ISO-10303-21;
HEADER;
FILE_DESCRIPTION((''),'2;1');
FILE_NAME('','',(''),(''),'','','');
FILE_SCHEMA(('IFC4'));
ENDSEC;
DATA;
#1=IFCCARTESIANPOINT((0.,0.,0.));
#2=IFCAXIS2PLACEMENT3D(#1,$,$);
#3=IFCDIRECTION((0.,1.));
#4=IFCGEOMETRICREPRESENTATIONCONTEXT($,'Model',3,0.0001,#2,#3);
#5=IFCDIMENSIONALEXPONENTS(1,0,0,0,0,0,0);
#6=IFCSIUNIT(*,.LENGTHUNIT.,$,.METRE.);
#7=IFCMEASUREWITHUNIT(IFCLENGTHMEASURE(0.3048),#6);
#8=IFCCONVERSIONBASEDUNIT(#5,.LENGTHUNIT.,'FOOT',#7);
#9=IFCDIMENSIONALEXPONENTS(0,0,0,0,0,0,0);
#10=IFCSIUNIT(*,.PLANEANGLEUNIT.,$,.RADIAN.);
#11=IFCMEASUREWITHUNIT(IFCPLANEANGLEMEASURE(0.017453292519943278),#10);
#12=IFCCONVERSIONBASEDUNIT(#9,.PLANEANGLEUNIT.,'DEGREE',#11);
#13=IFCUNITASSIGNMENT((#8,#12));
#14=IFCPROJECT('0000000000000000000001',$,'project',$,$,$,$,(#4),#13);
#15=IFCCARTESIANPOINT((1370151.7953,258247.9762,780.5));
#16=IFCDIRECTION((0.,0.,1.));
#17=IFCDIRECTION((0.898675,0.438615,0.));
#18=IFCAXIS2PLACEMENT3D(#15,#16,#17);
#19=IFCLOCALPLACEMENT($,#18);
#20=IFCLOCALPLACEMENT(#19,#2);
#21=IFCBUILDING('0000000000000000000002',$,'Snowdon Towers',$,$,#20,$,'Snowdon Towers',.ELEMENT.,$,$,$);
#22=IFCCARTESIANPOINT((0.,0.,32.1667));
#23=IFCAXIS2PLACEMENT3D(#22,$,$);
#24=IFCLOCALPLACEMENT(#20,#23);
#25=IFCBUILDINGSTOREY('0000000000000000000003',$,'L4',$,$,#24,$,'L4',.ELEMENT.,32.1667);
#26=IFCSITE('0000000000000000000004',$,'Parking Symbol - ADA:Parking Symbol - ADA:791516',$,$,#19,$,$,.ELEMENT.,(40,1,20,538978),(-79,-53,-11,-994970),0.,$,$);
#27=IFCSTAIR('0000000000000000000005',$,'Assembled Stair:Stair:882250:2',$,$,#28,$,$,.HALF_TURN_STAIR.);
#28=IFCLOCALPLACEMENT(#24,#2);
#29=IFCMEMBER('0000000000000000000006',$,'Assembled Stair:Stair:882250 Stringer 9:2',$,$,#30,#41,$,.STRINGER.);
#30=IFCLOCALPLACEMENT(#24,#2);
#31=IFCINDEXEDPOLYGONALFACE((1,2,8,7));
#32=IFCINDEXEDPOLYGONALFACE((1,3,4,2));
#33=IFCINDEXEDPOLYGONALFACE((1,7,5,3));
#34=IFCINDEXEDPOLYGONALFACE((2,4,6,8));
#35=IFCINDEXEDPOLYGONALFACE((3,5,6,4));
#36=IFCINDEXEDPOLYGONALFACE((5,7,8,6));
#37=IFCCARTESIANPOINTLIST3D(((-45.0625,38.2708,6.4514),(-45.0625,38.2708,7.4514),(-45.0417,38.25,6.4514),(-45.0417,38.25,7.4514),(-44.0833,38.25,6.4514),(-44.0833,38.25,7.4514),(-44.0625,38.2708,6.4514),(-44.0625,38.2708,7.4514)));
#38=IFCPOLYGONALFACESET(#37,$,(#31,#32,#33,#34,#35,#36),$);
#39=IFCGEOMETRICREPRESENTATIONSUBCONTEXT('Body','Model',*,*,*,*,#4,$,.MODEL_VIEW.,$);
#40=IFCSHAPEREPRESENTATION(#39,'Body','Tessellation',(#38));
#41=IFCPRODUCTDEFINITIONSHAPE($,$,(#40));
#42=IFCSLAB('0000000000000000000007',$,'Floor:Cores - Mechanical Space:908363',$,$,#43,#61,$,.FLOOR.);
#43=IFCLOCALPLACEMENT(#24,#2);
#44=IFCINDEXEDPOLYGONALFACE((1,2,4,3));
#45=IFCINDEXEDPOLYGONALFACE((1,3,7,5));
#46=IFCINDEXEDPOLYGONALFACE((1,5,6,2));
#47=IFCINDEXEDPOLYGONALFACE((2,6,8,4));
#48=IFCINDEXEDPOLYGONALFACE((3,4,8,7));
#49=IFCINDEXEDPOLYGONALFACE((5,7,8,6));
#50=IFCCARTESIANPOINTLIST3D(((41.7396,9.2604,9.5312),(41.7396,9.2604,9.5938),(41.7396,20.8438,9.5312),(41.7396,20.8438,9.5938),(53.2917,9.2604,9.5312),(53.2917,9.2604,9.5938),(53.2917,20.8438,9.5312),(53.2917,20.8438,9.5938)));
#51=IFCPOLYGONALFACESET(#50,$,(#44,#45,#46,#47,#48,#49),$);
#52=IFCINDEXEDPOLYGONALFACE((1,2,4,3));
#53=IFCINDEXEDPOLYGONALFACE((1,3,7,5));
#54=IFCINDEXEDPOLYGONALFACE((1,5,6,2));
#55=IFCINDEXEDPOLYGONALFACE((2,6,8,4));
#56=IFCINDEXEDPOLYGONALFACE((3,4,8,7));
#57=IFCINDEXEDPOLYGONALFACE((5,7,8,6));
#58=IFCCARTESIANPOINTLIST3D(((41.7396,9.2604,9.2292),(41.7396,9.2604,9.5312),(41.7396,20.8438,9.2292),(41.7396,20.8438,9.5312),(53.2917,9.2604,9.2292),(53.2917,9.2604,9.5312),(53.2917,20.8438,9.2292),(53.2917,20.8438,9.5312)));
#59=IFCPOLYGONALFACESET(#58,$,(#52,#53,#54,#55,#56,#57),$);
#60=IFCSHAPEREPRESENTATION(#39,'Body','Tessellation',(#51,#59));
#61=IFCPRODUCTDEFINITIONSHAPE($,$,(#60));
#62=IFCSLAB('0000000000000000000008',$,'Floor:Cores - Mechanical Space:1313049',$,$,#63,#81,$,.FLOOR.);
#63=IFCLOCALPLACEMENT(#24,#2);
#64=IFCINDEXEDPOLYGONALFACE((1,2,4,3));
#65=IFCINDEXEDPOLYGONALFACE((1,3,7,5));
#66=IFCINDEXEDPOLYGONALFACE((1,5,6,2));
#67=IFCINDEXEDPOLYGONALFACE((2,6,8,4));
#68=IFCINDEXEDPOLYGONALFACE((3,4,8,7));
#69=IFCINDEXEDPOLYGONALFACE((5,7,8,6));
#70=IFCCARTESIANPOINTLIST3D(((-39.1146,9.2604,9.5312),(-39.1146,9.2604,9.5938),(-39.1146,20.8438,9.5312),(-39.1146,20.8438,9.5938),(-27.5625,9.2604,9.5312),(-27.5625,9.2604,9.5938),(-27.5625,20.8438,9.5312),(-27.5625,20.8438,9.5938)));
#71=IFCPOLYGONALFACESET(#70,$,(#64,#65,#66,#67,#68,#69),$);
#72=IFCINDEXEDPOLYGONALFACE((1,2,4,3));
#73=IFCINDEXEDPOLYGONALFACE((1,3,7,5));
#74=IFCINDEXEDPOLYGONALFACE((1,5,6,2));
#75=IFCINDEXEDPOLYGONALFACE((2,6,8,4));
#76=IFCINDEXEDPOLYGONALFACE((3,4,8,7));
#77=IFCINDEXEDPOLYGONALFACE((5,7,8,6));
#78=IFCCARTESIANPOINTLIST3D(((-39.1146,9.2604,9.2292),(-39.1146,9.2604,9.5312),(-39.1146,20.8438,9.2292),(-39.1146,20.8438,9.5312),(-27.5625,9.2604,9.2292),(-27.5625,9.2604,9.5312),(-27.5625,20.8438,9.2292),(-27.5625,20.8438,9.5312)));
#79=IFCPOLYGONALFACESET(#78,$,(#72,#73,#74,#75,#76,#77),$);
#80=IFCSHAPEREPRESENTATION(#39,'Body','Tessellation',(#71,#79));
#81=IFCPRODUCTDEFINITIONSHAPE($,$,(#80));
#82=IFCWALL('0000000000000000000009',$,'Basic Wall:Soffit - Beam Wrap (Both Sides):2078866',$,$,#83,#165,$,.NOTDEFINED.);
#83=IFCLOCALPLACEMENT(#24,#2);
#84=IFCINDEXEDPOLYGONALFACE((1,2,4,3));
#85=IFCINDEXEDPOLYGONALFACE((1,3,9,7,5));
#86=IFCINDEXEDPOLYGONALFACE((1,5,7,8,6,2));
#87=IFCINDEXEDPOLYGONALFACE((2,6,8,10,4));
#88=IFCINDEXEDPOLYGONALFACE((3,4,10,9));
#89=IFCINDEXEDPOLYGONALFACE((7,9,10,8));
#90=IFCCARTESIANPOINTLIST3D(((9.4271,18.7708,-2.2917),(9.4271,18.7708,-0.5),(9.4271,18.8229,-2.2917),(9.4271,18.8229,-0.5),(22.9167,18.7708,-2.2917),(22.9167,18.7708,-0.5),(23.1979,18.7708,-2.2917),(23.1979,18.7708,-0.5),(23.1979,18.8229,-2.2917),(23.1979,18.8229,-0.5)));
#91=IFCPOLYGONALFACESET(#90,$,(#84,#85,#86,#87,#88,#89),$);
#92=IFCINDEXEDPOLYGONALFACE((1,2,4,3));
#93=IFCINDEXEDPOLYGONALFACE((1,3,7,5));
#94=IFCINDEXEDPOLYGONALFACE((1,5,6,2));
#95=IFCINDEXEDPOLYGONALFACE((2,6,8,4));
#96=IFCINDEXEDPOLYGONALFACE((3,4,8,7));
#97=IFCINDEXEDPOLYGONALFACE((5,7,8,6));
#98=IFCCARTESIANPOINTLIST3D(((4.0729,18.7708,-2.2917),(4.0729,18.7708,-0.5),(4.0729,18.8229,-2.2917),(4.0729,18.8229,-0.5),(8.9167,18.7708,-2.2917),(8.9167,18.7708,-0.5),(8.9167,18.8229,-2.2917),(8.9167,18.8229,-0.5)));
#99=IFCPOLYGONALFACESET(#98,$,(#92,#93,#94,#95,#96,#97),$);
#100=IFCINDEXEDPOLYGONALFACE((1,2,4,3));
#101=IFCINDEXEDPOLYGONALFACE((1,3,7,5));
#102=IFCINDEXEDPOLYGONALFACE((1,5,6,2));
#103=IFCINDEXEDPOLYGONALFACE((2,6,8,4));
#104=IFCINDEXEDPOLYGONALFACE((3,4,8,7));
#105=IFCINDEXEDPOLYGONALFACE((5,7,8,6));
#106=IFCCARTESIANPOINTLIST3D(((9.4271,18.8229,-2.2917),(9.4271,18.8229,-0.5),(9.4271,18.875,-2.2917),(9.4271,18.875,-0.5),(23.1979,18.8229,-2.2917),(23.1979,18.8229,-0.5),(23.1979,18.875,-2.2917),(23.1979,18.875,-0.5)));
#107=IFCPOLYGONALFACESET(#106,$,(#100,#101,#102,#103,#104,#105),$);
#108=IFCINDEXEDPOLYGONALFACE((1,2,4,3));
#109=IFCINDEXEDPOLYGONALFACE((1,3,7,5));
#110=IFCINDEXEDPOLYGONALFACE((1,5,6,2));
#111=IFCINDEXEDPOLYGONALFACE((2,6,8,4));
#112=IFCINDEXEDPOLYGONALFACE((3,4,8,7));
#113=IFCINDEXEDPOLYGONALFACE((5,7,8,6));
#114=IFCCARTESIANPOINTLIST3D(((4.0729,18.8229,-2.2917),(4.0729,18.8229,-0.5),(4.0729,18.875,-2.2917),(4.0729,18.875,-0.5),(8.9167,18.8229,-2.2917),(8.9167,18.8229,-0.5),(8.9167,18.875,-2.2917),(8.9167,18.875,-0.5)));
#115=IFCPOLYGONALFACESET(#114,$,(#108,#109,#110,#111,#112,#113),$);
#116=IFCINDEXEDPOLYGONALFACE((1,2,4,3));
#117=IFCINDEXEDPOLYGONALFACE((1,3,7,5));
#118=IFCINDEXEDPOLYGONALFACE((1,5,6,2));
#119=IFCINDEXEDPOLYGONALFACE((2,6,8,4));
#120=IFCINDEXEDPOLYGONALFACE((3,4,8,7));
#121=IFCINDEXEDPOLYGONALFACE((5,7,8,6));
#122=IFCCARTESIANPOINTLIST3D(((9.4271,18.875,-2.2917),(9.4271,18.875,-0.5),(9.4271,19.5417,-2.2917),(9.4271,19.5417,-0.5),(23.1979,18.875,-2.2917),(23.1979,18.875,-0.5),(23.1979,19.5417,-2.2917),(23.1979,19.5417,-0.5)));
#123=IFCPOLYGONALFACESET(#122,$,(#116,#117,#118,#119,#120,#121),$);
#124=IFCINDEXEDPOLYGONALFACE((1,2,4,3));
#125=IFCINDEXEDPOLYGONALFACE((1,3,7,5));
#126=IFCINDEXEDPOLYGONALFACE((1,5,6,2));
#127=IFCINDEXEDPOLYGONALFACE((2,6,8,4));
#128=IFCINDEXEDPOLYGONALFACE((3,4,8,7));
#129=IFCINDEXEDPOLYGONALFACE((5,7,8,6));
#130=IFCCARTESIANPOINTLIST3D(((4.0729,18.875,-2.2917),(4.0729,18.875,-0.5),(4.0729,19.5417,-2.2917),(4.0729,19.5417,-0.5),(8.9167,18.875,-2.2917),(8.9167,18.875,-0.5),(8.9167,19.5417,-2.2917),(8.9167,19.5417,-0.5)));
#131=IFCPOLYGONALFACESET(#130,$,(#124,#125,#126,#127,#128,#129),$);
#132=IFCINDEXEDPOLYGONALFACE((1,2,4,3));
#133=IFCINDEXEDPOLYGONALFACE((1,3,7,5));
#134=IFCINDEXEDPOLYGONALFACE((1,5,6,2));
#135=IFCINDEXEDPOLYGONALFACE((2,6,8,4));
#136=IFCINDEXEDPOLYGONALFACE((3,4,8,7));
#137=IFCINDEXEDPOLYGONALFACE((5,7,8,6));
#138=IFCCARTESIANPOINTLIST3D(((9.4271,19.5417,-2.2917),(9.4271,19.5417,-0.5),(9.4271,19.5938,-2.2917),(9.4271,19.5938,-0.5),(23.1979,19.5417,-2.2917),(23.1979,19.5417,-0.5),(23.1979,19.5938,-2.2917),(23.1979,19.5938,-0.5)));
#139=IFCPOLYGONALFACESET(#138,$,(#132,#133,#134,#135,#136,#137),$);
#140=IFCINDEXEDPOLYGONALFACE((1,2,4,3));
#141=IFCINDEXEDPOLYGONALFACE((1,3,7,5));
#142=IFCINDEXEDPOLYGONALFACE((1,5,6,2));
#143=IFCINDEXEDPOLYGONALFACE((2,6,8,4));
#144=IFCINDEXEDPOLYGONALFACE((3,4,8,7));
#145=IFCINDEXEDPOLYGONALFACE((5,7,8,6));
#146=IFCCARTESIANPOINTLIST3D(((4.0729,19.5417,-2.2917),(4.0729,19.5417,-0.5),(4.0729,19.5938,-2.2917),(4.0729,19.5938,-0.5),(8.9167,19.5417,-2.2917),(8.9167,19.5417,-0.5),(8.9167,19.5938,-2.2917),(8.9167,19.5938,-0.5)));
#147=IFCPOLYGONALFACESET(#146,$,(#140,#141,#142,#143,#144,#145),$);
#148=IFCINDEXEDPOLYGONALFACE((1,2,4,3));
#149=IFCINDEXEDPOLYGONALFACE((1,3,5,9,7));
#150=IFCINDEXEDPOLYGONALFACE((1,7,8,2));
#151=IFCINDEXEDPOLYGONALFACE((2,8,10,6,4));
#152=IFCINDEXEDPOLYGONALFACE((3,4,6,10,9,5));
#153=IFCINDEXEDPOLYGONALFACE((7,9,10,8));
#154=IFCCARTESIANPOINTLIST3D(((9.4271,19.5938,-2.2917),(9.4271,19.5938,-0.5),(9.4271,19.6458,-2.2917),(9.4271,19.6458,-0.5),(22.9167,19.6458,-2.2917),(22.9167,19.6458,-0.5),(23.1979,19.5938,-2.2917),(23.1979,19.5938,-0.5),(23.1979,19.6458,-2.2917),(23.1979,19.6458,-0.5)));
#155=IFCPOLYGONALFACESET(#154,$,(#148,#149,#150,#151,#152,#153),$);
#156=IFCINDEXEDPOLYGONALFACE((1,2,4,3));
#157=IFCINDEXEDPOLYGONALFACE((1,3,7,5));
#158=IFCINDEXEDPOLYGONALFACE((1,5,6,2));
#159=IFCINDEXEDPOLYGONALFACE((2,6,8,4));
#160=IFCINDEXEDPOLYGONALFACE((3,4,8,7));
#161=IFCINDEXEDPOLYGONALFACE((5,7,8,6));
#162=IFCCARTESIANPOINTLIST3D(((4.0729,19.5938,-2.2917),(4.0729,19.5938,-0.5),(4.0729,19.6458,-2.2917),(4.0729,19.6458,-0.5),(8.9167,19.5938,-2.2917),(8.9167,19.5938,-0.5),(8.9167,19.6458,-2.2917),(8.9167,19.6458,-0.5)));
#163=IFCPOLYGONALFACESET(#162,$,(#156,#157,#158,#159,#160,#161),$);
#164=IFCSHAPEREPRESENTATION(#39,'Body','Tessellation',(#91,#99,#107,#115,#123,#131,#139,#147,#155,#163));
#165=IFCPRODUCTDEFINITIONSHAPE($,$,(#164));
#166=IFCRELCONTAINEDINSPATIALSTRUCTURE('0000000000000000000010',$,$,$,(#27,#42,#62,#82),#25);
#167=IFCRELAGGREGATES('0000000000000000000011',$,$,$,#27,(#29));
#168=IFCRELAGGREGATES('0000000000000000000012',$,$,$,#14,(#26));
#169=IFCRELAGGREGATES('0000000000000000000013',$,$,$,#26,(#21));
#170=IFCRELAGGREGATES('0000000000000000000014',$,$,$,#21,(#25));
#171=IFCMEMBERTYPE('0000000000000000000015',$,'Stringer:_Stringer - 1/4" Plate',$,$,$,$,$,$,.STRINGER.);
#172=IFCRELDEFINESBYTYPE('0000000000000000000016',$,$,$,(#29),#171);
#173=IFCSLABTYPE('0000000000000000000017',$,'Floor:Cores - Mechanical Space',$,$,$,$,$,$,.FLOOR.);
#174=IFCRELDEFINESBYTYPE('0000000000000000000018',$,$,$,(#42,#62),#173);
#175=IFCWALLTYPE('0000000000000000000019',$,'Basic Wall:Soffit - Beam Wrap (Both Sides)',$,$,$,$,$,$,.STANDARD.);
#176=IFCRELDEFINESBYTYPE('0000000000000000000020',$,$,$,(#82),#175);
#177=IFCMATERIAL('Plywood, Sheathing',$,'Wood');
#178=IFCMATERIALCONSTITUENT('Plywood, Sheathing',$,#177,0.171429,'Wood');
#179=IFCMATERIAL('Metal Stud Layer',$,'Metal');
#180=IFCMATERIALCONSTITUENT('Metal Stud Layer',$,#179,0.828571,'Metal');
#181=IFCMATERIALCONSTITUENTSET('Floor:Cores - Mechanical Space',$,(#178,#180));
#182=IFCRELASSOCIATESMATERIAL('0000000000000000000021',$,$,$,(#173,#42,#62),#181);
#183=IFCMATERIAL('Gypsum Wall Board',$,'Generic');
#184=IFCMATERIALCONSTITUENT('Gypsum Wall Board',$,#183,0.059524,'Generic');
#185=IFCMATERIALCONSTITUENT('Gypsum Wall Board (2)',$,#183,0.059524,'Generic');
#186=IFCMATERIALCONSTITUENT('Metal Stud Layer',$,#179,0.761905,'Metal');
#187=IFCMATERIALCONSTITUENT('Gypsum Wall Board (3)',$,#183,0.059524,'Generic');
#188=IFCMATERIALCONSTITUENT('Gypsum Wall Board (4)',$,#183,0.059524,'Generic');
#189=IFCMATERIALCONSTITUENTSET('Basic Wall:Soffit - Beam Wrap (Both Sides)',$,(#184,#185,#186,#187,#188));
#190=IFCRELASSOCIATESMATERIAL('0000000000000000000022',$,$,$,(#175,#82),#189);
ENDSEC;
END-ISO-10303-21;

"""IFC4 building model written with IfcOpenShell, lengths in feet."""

from ifc_helpers import new_model, entity, si_unit, converted_unit, direction, frame, origin, place, context, subcontext, project, spatial, indexed_curve, outline, extrude, material, constituent, constituent_set, type_object, element, aggregate, save


model = new_model("IFC4")

# Units and contexts
model_context = context("Model", 3, precision=0.0001, world=origin(), true_north=direction((0.0, 1.0)))
body_context = subcontext(model_context, "Body", "Model", "MODEL_VIEW")
ifc_project = project(units=[converted_unit("LENGTHUNIT", "FOOT", entity("IfcLengthMeasure", 0.3048), si_unit("LENGTHUNIT", "METRE"), dimensions=[1, 0, 0, 0, 0, 0, 0]), converted_unit("PLANEANGLEUNIT", "DEGREE", entity("IfcPlaneAngleMeasure", 0.017453292519943278), si_unit("PLANEANGLEUNIT", "RADIAN"), dimensions=[0, 0, 0, 0, 0, 0, 0])], contexts=[model_context])

# Site, building, storey
site_placement = place(None, frame((1370151.7953, 258247.9762, 780.5), z_axis=(0.0, 0.0, 1.0), x_axis=(0.898675, 0.438615, 0.0)))
site = spatial("IfcSite", under=ifc_project, at=site_placement, Name="Parking Symbol - ADA:Parking Symbol - ADA:791516", CompositionType="ELEMENT", RefLatitude=(40, 1, 20, 538978), RefLongitude=(-79, -53, -11, -994970), RefElevation=0.0)
building_placement = place(site_placement, origin())
building = spatial("IfcBuilding", under=site, at=building_placement, Name="Snowdon Towers", LongName="Snowdon Towers", CompositionType="ELEMENT")
storey_placement = place(building_placement, frame((0.0, 0.0, 32.1667)))
storey = spatial("IfcBuildingStorey", under=building, at=storey_placement, Name="L4", LongName="L4", CompositionType="ELEMENT", Elevation=32.1667)

# Shared definitions
ifc_material_1 = material(Name="Gypsum Wall Board", Category="Generic")

# Stair, member
stair_placement = place(storey_placement, origin())
stair = element("IfcStair", 1, at=stair_placement, inside=storey, Name="Assembled Stair:Stair:882250:2", PredefinedType="HALF_TURN_STAIR")
member_type = type_object("IfcMemberType", Name="Stringer:_Stringer - 1/4\" Plate", PredefinedType="STRINGER")
member_1_placement = place(stair_placement, origin())
member_1 = element("IfcMember", 2, at=member_1_placement, type_object=member_type, Name="Assembled Stair:Stair:882250 Stringer 9:2", PredefinedType="STRINGER", context=body_context, shape_type="SweptSolid", body=[
    extrude(outline(indexed_curve([(-0.4792, -0.0104), (0.4792, -0.0104), (0.5, 0.0104), (-0.5, 0.0104), (-0.4792, -0.0104)], self_intersect=False)), frame((-44.5625, 38.2604, 6.4514)), (0.0, 0.0, 1.0), 1.0),
])
aggregate(stair, [member_1])

# Slabs
ifc_material_2 = material(Name="Plywood, Sheathing", Category="Wood")
ifc_constituent_1 = constituent(ifc_material_2, Name="Plywood, Sheathing", Category="Wood", fraction=0.171429)
ifc_material_3 = material(Name="Metal Stud Layer", Category="Metal")
ifc_constituent_2 = constituent(ifc_material_3, Name="Metal Stud Layer", Category="Metal", fraction=0.828571)
ifc_constituent_set_1 = constituent_set(constituents=[ifc_constituent_1, ifc_constituent_2], Name="Floor:Cores - Mechanical Space")
slab_type_1 = type_object("IfcSlabType", Name="Floor:Cores - Mechanical Space", PredefinedType="FLOOR", material=ifc_constituent_set_1)
slab_1_placement = place(storey_placement, origin())
element("IfcSlab", 3, at=slab_1_placement, inside=storey, type_object=slab_type_1, material=ifc_constituent_set_1, Name="Floor:Cores - Mechanical Space:908363", PredefinedType="FLOOR", context=body_context, shape_type="SweptSolid", body=[
    extrude(outline(indexed_curve([(-5.7917, -5.776), (5.7917, -5.776), (5.7917, 5.776), (-5.7917, 5.776), (-5.7917, -5.776)], self_intersect=False)), frame((47.5156, 15.0521, 9.5312), z_axis=(0.0, 0.0, 1.0), x_axis=(0.0, 1.0, 0.0)), (0.0, 0.0, 1.0), 0.0625),
    extrude(outline(indexed_curve([(-5.7917, -5.776), (5.7917, -5.776), (5.7917, 5.776), (-5.7917, 5.776), (-5.7917, -5.776)], self_intersect=False)), frame((47.5156, 15.0521, 9.2292), z_axis=(0.0, 0.0, 1.0), x_axis=(0.0, 1.0, 0.0)), (0.0, 0.0, 1.0), 0.3021),
])
slab_2_placement = place(storey_placement, origin())
element("IfcSlab", 4, at=slab_2_placement, inside=storey, type_object=slab_type_1, material=ifc_constituent_set_1, Name="Floor:Cores - Mechanical Space:1313049", PredefinedType="FLOOR", context=body_context, shape_type="SweptSolid", body=[
    extrude(outline(indexed_curve([(-5.7917, -5.776), (5.7917, -5.776), (5.7917, 5.776), (-5.7917, 5.776), (-5.7917, -5.776)], self_intersect=False)), frame((-33.3385, 15.0521, 9.5312), z_axis=(0.0, 0.0, 1.0), x_axis=(0.0, 1.0, 0.0)), (0.0, 0.0, 1.0), 0.0625),
    extrude(outline(indexed_curve([(-5.7917, -5.776), (5.7917, -5.776), (5.7917, 5.776), (-5.7917, 5.776), (-5.7917, -5.776)], self_intersect=False)), frame((-33.3385, 15.0521, 9.2292), z_axis=(0.0, 0.0, 1.0), x_axis=(0.0, 1.0, 0.0)), (0.0, 0.0, 1.0), 0.3021),
])

# Wall
ifc_constituent_3 = constituent(ifc_material_1, Name="Gypsum Wall Board", Category="Generic", fraction=0.059524)
ifc_constituent_4 = constituent(ifc_material_1, Name="Gypsum Wall Board (2)", Category="Generic", fraction=0.059524)
ifc_constituent_5 = constituent(ifc_material_3, Name="Metal Stud Layer", Category="Metal", fraction=0.761905)
ifc_constituent_6 = constituent(ifc_material_1, Name="Gypsum Wall Board (3)", Category="Generic", fraction=0.059524)
ifc_constituent_7 = constituent(ifc_material_1, Name="Gypsum Wall Board (4)", Category="Generic", fraction=0.059524)
ifc_constituent_set_2 = constituent_set(constituents=[ifc_constituent_3, ifc_constituent_4, ifc_constituent_5, ifc_constituent_6, ifc_constituent_7], Name="Basic Wall:Soffit - Beam Wrap (Both Sides)")
wall_type_1 = type_object("IfcWallType", Name="Basic Wall:Soffit - Beam Wrap (Both Sides)", PredefinedType="STANDARD", material=ifc_constituent_set_2)
wall_1_placement = place(storey_placement, frame((4.0729, 19.2083, -2.2917)))
element("IfcWall", 5, at=wall_1_placement, inside=storey, type_object=wall_type_1, material=ifc_constituent_set_2, Name="Basic Wall:Soffit - Beam Wrap (Both Sides):2078866", PredefinedType="NOTDEFINED", context=body_context, shape_type="SweptSolid", body=[
    extrude(outline(indexed_curve([(5.2833, -0.0208), (5.5646, -0.0208), (5.5646, 0.0313), (-8.2063, 0.0312), (-8.2063, -0.0208), (5.2833, -0.0208)], self_intersect=False)), frame((13.5604, -0.4167, 0.0)), (0.0, 0.0, 1.0), 1.7917),
    extrude(outline(indexed_curve([(-0.026, -2.4219), (0.026, -2.4219), (0.026, 2.4219), (-0.026, 2.4219), (-0.026, -2.4219)], self_intersect=False)), frame((2.4219, -0.4115, 0.0), z_axis=(0.0, 0.0, 1.0), x_axis=(0.0, 1.0, 0.0)), (0.0, 0.0, 1.0), 1.7917),
    extrude(outline(indexed_curve([(-6.8854, -0.026), (6.8854, -0.026), (6.8854, 0.026), (-6.8854, 0.026), (-6.8854, -0.026)], self_intersect=False)), frame((12.2396, -0.3594, 0.0)), (0.0, 0.0, 1.0), 1.7917),
    extrude(outline(indexed_curve([(-2.4219, -0.026), (2.4219, -0.026), (2.4219, 0.026), (-2.4219, 0.026), (-2.4219, -0.026)], self_intersect=False)), frame((2.4219, -0.3594, 0.0)), (0.0, 0.0, 1.0), 1.7917),
    extrude(outline(indexed_curve([(-6.8854, -0.3333), (6.8854, -0.3333), (6.8854, 0.3333), (-6.8854, 0.3333), (-6.8854, -0.3333)], self_intersect=False)), frame((12.2396, 0.0, 0.0)), (0.0, 0.0, 1.0), 1.7917),
    extrude(outline(indexed_curve([(-2.4219, -0.3333), (2.4219, -0.3333), (2.4219, 0.3333), (-2.4219, 0.3333), (-2.4219, -0.3333)], self_intersect=False)), frame((2.4219, 0.0, 0.0)), (0.0, 0.0, 1.0), 1.7917),
    extrude(outline(indexed_curve([(-6.8854, -0.026), (6.8854, -0.026), (6.8854, 0.026), (-6.8854, 0.026), (-6.8854, -0.026)], self_intersect=False)), frame((12.2396, 0.3594, 0.0)), (0.0, 0.0, 1.0), 1.7917),
    extrude(outline(indexed_curve([(-2.4219, -0.026), (2.4219, -0.026), (2.4219, 0.026), (-2.4219, 0.026), (-2.4219, -0.026)], self_intersect=False)), frame((2.4219, 0.3594, 0.0)), (0.0, 0.0, 1.0), 1.7917),
    extrude(outline(indexed_curve([(-5.2833, -0.0208), (8.2063, -0.0208), (8.2063, 0.0312), (-5.5646, 0.0313), (-5.5646, -0.0208), (-5.2833, -0.0208)], self_intersect=False)), frame((13.5604, 0.4167, 0.0), z_axis=(0.0, 0.0, 1.0), x_axis=(-1.0, 0.0, 0.0)), (0.0, 0.0, 1.0), 1.7917),
    extrude(outline(indexed_curve([(-0.026, -2.4219), (0.026, -2.4219), (0.026, 2.4219), (-0.026, 2.4219), (-0.026, -2.4219)], self_intersect=False)), frame((2.4219, 0.4115, 0.0), z_axis=(0.0, 0.0, 1.0), x_axis=(0.0, -1.0, 0.0)), (0.0, 0.0, 1.0), 1.7917),
])

save(model, "model.ifc")
